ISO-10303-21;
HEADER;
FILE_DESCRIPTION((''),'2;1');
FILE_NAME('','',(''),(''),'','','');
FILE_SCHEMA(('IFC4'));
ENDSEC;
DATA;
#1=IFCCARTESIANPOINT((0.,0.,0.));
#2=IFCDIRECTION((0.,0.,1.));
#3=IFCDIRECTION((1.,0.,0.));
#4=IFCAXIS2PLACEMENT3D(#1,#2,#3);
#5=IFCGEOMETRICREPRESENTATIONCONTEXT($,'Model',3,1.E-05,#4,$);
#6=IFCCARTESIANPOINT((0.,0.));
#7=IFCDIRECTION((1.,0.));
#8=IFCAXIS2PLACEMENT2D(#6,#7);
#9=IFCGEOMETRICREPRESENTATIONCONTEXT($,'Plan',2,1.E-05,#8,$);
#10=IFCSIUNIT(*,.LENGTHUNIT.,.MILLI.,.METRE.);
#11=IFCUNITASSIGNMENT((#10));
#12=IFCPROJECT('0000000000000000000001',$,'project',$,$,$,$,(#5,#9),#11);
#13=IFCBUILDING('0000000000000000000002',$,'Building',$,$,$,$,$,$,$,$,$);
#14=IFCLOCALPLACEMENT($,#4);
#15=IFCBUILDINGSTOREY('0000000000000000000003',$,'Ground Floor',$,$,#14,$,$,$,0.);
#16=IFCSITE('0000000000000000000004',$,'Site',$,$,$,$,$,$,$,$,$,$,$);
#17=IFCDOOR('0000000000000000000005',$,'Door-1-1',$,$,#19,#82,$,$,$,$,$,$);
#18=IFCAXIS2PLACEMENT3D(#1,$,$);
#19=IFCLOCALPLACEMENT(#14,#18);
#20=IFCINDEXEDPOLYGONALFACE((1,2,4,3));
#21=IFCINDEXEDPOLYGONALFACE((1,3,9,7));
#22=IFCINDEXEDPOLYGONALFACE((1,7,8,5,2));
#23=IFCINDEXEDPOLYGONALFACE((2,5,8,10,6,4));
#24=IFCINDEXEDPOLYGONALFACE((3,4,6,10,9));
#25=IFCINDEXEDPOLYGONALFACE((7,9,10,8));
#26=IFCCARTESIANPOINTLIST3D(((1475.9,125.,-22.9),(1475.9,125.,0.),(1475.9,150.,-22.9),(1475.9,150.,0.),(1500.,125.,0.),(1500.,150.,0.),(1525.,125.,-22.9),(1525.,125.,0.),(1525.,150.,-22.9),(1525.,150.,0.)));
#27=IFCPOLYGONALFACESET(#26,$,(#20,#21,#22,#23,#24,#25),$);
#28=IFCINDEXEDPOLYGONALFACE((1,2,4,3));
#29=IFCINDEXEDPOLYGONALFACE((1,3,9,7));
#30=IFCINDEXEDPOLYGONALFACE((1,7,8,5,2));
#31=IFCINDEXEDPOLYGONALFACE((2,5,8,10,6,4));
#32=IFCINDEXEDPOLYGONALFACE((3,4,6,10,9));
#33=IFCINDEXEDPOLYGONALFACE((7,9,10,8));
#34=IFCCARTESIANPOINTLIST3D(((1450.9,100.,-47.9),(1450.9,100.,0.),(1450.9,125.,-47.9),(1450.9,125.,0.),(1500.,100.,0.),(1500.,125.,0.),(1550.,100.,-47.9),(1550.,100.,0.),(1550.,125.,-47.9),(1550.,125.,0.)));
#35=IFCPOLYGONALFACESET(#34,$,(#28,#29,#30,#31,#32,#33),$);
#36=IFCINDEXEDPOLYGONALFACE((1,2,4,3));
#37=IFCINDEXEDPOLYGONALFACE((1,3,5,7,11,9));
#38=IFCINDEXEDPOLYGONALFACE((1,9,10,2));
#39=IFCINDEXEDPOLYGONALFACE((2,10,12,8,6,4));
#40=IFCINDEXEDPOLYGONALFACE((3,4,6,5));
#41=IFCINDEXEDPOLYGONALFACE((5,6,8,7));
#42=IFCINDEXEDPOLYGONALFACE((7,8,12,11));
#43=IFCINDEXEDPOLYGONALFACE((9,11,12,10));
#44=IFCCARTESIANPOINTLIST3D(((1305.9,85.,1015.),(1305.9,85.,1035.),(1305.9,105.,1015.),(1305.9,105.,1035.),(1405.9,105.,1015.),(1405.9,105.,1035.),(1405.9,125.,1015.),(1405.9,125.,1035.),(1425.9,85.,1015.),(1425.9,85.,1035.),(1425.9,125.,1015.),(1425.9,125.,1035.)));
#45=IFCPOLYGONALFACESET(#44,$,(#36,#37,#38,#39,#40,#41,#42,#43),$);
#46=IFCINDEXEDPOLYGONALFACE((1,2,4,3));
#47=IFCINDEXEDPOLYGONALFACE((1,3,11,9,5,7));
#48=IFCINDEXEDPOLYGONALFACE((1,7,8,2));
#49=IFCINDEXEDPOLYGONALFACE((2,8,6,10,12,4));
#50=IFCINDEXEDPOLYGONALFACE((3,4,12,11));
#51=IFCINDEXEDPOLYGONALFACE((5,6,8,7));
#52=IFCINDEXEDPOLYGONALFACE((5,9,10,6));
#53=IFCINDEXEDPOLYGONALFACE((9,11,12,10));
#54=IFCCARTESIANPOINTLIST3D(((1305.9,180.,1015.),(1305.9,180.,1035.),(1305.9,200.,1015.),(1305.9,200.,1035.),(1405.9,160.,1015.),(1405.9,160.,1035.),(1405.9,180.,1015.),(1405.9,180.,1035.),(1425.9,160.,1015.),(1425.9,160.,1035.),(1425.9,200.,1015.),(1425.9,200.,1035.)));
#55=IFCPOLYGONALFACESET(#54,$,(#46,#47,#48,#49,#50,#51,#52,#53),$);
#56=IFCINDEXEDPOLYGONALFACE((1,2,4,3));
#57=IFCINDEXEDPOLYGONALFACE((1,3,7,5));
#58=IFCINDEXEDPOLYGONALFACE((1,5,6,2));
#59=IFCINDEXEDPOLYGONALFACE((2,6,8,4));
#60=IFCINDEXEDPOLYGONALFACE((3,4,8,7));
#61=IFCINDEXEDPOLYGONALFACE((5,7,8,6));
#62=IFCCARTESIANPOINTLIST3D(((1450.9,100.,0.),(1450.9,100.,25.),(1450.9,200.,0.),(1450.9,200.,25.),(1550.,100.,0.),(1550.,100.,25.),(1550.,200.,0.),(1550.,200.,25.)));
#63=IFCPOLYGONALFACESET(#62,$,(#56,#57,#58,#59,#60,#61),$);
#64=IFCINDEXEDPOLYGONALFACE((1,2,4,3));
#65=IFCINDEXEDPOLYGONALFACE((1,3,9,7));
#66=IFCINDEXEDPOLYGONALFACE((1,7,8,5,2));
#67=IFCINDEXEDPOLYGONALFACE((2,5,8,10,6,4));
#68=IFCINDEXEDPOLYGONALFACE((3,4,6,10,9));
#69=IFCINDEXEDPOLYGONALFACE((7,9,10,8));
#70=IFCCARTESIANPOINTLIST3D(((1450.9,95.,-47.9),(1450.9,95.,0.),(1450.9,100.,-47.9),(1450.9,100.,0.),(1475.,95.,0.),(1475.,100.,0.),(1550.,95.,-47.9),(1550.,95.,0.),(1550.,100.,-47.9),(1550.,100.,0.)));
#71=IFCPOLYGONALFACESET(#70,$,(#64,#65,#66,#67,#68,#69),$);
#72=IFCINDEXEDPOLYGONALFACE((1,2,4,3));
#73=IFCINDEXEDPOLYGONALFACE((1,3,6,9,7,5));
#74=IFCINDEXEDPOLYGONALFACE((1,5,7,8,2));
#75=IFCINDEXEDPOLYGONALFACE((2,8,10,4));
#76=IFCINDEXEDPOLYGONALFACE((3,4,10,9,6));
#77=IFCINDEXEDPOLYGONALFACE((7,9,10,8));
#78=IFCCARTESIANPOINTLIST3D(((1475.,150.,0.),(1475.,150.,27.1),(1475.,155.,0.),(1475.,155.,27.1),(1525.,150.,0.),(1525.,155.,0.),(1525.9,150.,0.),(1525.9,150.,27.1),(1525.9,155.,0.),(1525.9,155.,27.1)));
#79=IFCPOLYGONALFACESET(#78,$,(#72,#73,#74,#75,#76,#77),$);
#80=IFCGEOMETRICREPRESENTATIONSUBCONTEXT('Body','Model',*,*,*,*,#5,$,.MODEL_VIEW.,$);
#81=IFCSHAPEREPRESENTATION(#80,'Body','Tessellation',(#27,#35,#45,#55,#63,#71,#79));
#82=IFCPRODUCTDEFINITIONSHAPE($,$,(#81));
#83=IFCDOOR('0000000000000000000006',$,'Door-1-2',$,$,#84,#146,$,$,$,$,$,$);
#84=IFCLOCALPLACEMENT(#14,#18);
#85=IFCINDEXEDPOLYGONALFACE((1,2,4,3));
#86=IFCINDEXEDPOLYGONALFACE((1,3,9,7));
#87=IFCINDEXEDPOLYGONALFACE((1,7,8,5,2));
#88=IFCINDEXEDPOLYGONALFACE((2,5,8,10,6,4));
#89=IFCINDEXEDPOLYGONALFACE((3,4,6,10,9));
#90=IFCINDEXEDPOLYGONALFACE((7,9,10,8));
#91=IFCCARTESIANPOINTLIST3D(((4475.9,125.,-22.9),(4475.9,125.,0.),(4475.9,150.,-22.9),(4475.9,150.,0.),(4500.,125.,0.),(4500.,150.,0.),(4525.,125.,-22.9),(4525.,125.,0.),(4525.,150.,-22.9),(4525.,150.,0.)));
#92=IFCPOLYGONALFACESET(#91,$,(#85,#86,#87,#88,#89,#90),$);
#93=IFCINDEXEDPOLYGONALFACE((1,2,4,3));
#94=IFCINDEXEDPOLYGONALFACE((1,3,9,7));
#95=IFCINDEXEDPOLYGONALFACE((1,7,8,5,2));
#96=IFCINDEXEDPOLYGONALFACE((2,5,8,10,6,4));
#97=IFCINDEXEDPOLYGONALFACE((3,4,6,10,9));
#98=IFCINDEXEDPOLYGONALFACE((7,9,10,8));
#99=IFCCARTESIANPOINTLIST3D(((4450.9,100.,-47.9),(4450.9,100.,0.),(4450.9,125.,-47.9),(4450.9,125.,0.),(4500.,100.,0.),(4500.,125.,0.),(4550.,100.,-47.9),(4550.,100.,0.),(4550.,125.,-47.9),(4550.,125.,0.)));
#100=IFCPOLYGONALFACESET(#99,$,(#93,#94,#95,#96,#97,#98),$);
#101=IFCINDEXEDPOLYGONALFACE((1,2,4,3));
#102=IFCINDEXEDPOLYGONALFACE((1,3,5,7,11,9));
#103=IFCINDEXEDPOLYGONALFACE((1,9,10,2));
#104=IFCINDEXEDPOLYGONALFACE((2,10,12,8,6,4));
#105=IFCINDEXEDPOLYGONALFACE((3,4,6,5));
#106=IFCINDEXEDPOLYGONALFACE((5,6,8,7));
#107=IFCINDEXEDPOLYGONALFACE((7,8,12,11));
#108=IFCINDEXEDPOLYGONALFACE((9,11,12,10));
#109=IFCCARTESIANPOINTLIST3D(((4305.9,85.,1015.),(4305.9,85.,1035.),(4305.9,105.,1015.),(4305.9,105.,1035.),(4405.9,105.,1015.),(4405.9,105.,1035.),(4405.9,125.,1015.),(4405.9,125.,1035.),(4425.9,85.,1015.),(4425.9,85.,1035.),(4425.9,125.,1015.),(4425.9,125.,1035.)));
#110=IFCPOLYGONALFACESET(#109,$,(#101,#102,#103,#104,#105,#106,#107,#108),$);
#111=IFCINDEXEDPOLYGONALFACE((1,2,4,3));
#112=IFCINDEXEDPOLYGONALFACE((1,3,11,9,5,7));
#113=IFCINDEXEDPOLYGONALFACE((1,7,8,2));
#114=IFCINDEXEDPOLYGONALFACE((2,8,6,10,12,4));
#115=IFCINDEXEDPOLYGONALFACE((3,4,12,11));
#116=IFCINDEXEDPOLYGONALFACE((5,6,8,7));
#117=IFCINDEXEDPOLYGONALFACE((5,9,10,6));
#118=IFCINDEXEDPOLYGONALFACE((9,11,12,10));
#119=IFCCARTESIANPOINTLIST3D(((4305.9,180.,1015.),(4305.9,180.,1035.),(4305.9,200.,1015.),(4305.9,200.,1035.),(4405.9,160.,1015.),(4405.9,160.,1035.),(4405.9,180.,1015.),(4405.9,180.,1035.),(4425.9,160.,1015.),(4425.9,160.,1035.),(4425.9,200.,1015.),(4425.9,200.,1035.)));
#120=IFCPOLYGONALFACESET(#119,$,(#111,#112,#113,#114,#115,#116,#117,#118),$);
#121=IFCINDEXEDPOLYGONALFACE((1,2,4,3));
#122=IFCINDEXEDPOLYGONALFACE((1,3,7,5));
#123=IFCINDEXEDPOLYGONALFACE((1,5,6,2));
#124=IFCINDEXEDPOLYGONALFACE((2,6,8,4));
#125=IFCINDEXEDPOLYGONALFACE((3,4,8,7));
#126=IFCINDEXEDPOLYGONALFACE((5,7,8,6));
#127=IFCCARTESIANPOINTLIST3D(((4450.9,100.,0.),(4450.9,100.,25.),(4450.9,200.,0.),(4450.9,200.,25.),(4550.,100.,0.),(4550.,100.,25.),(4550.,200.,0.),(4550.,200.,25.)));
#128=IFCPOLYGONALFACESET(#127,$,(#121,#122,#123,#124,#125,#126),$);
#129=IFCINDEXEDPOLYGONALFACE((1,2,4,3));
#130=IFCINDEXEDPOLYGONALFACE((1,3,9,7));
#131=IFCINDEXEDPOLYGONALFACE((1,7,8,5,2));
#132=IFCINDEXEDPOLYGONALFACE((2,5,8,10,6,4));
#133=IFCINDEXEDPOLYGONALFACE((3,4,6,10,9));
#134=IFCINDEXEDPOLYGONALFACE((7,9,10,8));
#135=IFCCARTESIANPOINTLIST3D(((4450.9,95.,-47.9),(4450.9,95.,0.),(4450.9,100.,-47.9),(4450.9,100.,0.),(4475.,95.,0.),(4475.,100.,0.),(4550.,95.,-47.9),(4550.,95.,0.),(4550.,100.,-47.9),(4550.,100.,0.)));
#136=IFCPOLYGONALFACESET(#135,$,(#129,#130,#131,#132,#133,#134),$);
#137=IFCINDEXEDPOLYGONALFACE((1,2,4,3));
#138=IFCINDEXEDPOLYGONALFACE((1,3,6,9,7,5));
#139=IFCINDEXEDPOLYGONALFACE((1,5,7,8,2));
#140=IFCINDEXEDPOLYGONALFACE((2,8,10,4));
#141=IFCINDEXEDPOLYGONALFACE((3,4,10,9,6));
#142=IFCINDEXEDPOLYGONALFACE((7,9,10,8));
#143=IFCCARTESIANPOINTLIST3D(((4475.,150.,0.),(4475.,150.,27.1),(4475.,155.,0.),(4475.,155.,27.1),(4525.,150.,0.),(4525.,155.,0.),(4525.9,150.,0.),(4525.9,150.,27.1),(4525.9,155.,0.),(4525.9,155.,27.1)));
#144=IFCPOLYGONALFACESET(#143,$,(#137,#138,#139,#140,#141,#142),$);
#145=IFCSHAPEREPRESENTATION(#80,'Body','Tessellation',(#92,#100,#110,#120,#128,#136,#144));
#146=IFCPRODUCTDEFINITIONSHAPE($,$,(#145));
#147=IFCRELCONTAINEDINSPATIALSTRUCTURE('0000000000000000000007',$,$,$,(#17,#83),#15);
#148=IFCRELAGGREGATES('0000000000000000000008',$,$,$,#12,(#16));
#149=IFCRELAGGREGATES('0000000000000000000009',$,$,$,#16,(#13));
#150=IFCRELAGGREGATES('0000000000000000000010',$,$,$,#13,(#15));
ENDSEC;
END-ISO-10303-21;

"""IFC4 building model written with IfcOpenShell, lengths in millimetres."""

from ifc_helpers import new_model, si_unit, frame, origin_with_axes, origin_2d_with_axis, place, context, subcontext, project, spatial, line, indexed_curve, outline, extrude, element, save


model = new_model("IFC4")

# Units and contexts
model_context = context("Model", 3, precision=1e-05, world=origin_with_axes())
plan_context = context("Plan", 2, precision=1e-05, world=origin_2d_with_axis())
body_context = subcontext(model_context, "Body", "Model", "MODEL_VIEW")
ifc_project = project(units=[si_unit("LENGTHUNIT", "METRE", prefix="MILLI")], contexts=[model_context, plan_context])

# Site, building, storey
site = spatial("IfcSite", under=ifc_project, Name="Site")
building = spatial("IfcBuilding", under=site, Name="Building")
storey_placement = place(None, origin_with_axes())
storey = spatial("IfcBuildingStorey", under=building, at=storey_placement, Name="Ground Floor", Elevation=0.0)

# Doors
door_1_placement = place(storey_placement, frame((1500.0, 100.0, 0.0), z_axis=(0.0, 0.0, 1.0), x_axis=(1.0, 0.0, 0.0)))
element("IfcDoor", 1, at=door_1_placement, inside=storey, Name="Door-1-1", context=body_context, shape_type="SweptSolid", body=[
    extrude(outline(indexed_curve([(0.0, 0.0), (0.0, 2.1), (0.9, 2.1), (0.9, 0.0), (-24.1, 0.0), (-24.1, -22.9), (25.0, -22.9), (25.0, 0.0)], segments=[line(1, 2, 3, 4, 5, 6, 7, 8, 1)])), frame((0.0, 25.0, 0.0), z_axis=(0.0, -1.0, 0.0), x_axis=(1.0, 0.0, 0.0)), (0.0, 0.0, -1.0), 25.0),
    extrude(outline(indexed_curve([(0.0, 0.0), (0.0, 2.1), (0.9, 2.1), (0.9, 0.0), (-49.1, 0.0), (-49.1, -47.9), (50.0, -47.9), (50.0, 0.0)], segments=[line(1, 2, 3, 4, 5, 6, 7, 8, 1)])), frame((0.0, 0.0, 0.0), z_axis=(0.0, -1.0, 0.0), x_axis=(1.0, 0.0, 0.0)), (0.0, 0.0, -1.0), 25.0),
    extrude(outline(indexed_curve([(0.0, 0.0), (-49.1, 0.0), (-49.1, 35.0), (0.0, 35.0)], segments=[line(1, 2, 3, 4, 1)])), frame((25.0, 25.0, 25.0), z_axis=(0.0, 0.0, 1.0), x_axis=(1.0, 0.0, 0.0)), (0.0, 0.0, 1.0), -47.9),
    extrude(outline(indexed_curve([(0.0, 0.0), (0.0, -40.0), (-120.0, -40.0), (-120.0, -20.0), (-20.0, -20.0), (-20.0, 0.0)], segments=[line(1, 2, 3, 4, 5, 6, 1)])), frame((-74.1, 25.0, 1015.0), z_axis=(0.0, 0.0, 1.0), x_axis=(1.0, 0.0, 0.0)), (0.0, 0.0, 1.0), 20.0),
    extrude(outline(indexed_curve([(0.0, 0.0), (0.0, 40.0), (-120.0, 40.0), (-120.0, 20.0), (-20.0, 20.0), (-20.0, 0.0)], segments=[line(1, 2, 3, 4, 5, 6, 1)])), frame((-74.1, 60.0, 1015.0), z_axis=(0.0, 0.0, 1.0), x_axis=(1.0, 0.0, 0.0)), (0.0, 0.0, 1.0), 20.0),
    extrude(outline(indexed_curve([(0.0, 0.0), (-99.1, 0.0), (-99.1, 100.0), (0.0, 100.0)], segments=[line(1, 2, 3, 4, 1)])), frame((50.0, 0.0, 0.0), z_axis=(0.0, 0.0, 1.0), x_axis=(1.0, 0.0, 0.0)), (0.0, 0.0, 1.0), 25.0),
    extrude(outline(indexed_curve([(0.0, 0.0), (0.0, 27.1), (50.9, 27.1), (50.9, 0.0), (-24.1, 0.0), (-24.1, -47.9), (75.0, -47.9), (75.0, 0.0)], segments=[line(1, 2, 3, 4, 5, 6, 7, 8, 1)])), frame((-25.0, -5.0, 0.0), z_axis=(0.0, -1.0, 0.0), x_axis=(1.0, 0.0, 0.0)), (0.0, 0.0, -1.0), 5.0),
    extrude(outline(indexed_curve([(0.0, 0.0), (0.0, 27.1), (50.9, 27.1), (50.9, 0.0), (0.9, 0.0), (0.9, -22.9), (50.0, -22.9), (50.0, 0.0)], segments=[line(1, 2, 3, 4, 5, 6, 7, 8, 1)])), frame((-25.0, 50.0, 0.0), z_axis=(0.0, -1.0, 0.0), x_axis=(1.0, 0.0, 0.0)), (0.0, 0.0, -1.0), 5.0),
])
door_2_placement = place(storey_placement, frame((4500.0, 100.0, 0.0), z_axis=(0.0, 0.0, 1.0), x_axis=(1.0, 0.0, 0.0)))
element("IfcDoor", 2, at=door_2_placement, inside=storey, Name="Door-1-2", context=body_context, shape_type="SweptSolid", body=[
    extrude(outline(indexed_curve([(0.0, 0.0), (0.0, 2.1), (0.9, 2.1), (0.9, 0.0), (-24.1, 0.0), (-24.1, -22.9), (25.0, -22.9), (25.0, 0.0)], segments=[line(1, 2, 3, 4, 5, 6, 7, 8, 1)])), frame((0.0, 25.0, 0.0), z_axis=(0.0, -1.0, 0.0), x_axis=(1.0, 0.0, 0.0)), (0.0, 0.0, -1.0), 25.0),
    extrude(outline(indexed_curve([(0.0, 0.0), (0.0, 2.1), (0.9, 2.1), (0.9, 0.0), (-49.1, 0.0), (-49.1, -47.9), (50.0, -47.9), (50.0, 0.0)], segments=[line(1, 2, 3, 4, 5, 6, 7, 8, 1)])), frame((0.0, 0.0, 0.0), z_axis=(0.0, -1.0, 0.0), x_axis=(1.0, 0.0, 0.0)), (0.0, 0.0, -1.0), 25.0),
    extrude(outline(indexed_curve([(0.0, 0.0), (-49.1, 0.0), (-49.1, 35.0), (0.0, 35.0)], segments=[line(1, 2, 3, 4, 1)])), frame((25.0, 25.0, 25.0), z_axis=(0.0, 0.0, 1.0), x_axis=(1.0, 0.0, 0.0)), (0.0, 0.0, 1.0), -47.9),
    extrude(outline(indexed_curve([(0.0, 0.0), (0.0, -40.0), (-120.0, -40.0), (-120.0, -20.0), (-20.0, -20.0), (-20.0, 0.0)], segments=[line(1, 2, 3, 4, 5, 6, 1)])), frame((-74.1, 25.0, 1015.0), z_axis=(0.0, 0.0, 1.0), x_axis=(1.0, 0.0, 0.0)), (0.0, 0.0, 1.0), 20.0),
    extrude(outline(indexed_curve([(0.0, 0.0), (0.0, 40.0), (-120.0, 40.0), (-120.0, 20.0), (-20.0, 20.0), (-20.0, 0.0)], segments=[line(1, 2, 3, 4, 5, 6, 1)])), frame((-74.1, 60.0, 1015.0), z_axis=(0.0, 0.0, 1.0), x_axis=(1.0, 0.0, 0.0)), (0.0, 0.0, 1.0), 20.0),
    extrude(outline(indexed_curve([(0.0, 0.0), (-99.1, 0.0), (-99.1, 100.0), (0.0, 100.0)], segments=[line(1, 2, 3, 4, 1)])), frame((50.0, 0.0, 0.0), z_axis=(0.0, 0.0, 1.0), x_axis=(1.0, 0.0, 0.0)), (0.0, 0.0, 1.0), 25.0),
    extrude(outline(indexed_curve([(0.0, 0.0), (0.0, 27.1), (50.9, 27.1), (50.9, 0.0), (-24.1, 0.0), (-24.1, -47.9), (75.0, -47.9), (75.0, 0.0)], segments=[line(1, 2, 3, 4, 5, 6, 7, 8, 1)])), frame((-25.0, -5.0, 0.0), z_axis=(0.0, -1.0, 0.0), x_axis=(1.0, 0.0, 0.0)), (0.0, 0.0, -1.0), 5.0),
    extrude(outline(indexed_curve([(0.0, 0.0), (0.0, 27.1), (50.9, 27.1), (50.9, 0.0), (0.9, 0.0), (0.9, -22.9), (50.0, -22.9), (50.0, 0.0)], segments=[line(1, 2, 3, 4, 5, 6, 7, 8, 1)])), frame((-25.0, 50.0, 0.0), z_axis=(0.0, -1.0, 0.0), x_axis=(1.0, 0.0, 0.0)), (0.0, 0.0, -1.0), 5.0),
])

save(model, "model.ifc")
